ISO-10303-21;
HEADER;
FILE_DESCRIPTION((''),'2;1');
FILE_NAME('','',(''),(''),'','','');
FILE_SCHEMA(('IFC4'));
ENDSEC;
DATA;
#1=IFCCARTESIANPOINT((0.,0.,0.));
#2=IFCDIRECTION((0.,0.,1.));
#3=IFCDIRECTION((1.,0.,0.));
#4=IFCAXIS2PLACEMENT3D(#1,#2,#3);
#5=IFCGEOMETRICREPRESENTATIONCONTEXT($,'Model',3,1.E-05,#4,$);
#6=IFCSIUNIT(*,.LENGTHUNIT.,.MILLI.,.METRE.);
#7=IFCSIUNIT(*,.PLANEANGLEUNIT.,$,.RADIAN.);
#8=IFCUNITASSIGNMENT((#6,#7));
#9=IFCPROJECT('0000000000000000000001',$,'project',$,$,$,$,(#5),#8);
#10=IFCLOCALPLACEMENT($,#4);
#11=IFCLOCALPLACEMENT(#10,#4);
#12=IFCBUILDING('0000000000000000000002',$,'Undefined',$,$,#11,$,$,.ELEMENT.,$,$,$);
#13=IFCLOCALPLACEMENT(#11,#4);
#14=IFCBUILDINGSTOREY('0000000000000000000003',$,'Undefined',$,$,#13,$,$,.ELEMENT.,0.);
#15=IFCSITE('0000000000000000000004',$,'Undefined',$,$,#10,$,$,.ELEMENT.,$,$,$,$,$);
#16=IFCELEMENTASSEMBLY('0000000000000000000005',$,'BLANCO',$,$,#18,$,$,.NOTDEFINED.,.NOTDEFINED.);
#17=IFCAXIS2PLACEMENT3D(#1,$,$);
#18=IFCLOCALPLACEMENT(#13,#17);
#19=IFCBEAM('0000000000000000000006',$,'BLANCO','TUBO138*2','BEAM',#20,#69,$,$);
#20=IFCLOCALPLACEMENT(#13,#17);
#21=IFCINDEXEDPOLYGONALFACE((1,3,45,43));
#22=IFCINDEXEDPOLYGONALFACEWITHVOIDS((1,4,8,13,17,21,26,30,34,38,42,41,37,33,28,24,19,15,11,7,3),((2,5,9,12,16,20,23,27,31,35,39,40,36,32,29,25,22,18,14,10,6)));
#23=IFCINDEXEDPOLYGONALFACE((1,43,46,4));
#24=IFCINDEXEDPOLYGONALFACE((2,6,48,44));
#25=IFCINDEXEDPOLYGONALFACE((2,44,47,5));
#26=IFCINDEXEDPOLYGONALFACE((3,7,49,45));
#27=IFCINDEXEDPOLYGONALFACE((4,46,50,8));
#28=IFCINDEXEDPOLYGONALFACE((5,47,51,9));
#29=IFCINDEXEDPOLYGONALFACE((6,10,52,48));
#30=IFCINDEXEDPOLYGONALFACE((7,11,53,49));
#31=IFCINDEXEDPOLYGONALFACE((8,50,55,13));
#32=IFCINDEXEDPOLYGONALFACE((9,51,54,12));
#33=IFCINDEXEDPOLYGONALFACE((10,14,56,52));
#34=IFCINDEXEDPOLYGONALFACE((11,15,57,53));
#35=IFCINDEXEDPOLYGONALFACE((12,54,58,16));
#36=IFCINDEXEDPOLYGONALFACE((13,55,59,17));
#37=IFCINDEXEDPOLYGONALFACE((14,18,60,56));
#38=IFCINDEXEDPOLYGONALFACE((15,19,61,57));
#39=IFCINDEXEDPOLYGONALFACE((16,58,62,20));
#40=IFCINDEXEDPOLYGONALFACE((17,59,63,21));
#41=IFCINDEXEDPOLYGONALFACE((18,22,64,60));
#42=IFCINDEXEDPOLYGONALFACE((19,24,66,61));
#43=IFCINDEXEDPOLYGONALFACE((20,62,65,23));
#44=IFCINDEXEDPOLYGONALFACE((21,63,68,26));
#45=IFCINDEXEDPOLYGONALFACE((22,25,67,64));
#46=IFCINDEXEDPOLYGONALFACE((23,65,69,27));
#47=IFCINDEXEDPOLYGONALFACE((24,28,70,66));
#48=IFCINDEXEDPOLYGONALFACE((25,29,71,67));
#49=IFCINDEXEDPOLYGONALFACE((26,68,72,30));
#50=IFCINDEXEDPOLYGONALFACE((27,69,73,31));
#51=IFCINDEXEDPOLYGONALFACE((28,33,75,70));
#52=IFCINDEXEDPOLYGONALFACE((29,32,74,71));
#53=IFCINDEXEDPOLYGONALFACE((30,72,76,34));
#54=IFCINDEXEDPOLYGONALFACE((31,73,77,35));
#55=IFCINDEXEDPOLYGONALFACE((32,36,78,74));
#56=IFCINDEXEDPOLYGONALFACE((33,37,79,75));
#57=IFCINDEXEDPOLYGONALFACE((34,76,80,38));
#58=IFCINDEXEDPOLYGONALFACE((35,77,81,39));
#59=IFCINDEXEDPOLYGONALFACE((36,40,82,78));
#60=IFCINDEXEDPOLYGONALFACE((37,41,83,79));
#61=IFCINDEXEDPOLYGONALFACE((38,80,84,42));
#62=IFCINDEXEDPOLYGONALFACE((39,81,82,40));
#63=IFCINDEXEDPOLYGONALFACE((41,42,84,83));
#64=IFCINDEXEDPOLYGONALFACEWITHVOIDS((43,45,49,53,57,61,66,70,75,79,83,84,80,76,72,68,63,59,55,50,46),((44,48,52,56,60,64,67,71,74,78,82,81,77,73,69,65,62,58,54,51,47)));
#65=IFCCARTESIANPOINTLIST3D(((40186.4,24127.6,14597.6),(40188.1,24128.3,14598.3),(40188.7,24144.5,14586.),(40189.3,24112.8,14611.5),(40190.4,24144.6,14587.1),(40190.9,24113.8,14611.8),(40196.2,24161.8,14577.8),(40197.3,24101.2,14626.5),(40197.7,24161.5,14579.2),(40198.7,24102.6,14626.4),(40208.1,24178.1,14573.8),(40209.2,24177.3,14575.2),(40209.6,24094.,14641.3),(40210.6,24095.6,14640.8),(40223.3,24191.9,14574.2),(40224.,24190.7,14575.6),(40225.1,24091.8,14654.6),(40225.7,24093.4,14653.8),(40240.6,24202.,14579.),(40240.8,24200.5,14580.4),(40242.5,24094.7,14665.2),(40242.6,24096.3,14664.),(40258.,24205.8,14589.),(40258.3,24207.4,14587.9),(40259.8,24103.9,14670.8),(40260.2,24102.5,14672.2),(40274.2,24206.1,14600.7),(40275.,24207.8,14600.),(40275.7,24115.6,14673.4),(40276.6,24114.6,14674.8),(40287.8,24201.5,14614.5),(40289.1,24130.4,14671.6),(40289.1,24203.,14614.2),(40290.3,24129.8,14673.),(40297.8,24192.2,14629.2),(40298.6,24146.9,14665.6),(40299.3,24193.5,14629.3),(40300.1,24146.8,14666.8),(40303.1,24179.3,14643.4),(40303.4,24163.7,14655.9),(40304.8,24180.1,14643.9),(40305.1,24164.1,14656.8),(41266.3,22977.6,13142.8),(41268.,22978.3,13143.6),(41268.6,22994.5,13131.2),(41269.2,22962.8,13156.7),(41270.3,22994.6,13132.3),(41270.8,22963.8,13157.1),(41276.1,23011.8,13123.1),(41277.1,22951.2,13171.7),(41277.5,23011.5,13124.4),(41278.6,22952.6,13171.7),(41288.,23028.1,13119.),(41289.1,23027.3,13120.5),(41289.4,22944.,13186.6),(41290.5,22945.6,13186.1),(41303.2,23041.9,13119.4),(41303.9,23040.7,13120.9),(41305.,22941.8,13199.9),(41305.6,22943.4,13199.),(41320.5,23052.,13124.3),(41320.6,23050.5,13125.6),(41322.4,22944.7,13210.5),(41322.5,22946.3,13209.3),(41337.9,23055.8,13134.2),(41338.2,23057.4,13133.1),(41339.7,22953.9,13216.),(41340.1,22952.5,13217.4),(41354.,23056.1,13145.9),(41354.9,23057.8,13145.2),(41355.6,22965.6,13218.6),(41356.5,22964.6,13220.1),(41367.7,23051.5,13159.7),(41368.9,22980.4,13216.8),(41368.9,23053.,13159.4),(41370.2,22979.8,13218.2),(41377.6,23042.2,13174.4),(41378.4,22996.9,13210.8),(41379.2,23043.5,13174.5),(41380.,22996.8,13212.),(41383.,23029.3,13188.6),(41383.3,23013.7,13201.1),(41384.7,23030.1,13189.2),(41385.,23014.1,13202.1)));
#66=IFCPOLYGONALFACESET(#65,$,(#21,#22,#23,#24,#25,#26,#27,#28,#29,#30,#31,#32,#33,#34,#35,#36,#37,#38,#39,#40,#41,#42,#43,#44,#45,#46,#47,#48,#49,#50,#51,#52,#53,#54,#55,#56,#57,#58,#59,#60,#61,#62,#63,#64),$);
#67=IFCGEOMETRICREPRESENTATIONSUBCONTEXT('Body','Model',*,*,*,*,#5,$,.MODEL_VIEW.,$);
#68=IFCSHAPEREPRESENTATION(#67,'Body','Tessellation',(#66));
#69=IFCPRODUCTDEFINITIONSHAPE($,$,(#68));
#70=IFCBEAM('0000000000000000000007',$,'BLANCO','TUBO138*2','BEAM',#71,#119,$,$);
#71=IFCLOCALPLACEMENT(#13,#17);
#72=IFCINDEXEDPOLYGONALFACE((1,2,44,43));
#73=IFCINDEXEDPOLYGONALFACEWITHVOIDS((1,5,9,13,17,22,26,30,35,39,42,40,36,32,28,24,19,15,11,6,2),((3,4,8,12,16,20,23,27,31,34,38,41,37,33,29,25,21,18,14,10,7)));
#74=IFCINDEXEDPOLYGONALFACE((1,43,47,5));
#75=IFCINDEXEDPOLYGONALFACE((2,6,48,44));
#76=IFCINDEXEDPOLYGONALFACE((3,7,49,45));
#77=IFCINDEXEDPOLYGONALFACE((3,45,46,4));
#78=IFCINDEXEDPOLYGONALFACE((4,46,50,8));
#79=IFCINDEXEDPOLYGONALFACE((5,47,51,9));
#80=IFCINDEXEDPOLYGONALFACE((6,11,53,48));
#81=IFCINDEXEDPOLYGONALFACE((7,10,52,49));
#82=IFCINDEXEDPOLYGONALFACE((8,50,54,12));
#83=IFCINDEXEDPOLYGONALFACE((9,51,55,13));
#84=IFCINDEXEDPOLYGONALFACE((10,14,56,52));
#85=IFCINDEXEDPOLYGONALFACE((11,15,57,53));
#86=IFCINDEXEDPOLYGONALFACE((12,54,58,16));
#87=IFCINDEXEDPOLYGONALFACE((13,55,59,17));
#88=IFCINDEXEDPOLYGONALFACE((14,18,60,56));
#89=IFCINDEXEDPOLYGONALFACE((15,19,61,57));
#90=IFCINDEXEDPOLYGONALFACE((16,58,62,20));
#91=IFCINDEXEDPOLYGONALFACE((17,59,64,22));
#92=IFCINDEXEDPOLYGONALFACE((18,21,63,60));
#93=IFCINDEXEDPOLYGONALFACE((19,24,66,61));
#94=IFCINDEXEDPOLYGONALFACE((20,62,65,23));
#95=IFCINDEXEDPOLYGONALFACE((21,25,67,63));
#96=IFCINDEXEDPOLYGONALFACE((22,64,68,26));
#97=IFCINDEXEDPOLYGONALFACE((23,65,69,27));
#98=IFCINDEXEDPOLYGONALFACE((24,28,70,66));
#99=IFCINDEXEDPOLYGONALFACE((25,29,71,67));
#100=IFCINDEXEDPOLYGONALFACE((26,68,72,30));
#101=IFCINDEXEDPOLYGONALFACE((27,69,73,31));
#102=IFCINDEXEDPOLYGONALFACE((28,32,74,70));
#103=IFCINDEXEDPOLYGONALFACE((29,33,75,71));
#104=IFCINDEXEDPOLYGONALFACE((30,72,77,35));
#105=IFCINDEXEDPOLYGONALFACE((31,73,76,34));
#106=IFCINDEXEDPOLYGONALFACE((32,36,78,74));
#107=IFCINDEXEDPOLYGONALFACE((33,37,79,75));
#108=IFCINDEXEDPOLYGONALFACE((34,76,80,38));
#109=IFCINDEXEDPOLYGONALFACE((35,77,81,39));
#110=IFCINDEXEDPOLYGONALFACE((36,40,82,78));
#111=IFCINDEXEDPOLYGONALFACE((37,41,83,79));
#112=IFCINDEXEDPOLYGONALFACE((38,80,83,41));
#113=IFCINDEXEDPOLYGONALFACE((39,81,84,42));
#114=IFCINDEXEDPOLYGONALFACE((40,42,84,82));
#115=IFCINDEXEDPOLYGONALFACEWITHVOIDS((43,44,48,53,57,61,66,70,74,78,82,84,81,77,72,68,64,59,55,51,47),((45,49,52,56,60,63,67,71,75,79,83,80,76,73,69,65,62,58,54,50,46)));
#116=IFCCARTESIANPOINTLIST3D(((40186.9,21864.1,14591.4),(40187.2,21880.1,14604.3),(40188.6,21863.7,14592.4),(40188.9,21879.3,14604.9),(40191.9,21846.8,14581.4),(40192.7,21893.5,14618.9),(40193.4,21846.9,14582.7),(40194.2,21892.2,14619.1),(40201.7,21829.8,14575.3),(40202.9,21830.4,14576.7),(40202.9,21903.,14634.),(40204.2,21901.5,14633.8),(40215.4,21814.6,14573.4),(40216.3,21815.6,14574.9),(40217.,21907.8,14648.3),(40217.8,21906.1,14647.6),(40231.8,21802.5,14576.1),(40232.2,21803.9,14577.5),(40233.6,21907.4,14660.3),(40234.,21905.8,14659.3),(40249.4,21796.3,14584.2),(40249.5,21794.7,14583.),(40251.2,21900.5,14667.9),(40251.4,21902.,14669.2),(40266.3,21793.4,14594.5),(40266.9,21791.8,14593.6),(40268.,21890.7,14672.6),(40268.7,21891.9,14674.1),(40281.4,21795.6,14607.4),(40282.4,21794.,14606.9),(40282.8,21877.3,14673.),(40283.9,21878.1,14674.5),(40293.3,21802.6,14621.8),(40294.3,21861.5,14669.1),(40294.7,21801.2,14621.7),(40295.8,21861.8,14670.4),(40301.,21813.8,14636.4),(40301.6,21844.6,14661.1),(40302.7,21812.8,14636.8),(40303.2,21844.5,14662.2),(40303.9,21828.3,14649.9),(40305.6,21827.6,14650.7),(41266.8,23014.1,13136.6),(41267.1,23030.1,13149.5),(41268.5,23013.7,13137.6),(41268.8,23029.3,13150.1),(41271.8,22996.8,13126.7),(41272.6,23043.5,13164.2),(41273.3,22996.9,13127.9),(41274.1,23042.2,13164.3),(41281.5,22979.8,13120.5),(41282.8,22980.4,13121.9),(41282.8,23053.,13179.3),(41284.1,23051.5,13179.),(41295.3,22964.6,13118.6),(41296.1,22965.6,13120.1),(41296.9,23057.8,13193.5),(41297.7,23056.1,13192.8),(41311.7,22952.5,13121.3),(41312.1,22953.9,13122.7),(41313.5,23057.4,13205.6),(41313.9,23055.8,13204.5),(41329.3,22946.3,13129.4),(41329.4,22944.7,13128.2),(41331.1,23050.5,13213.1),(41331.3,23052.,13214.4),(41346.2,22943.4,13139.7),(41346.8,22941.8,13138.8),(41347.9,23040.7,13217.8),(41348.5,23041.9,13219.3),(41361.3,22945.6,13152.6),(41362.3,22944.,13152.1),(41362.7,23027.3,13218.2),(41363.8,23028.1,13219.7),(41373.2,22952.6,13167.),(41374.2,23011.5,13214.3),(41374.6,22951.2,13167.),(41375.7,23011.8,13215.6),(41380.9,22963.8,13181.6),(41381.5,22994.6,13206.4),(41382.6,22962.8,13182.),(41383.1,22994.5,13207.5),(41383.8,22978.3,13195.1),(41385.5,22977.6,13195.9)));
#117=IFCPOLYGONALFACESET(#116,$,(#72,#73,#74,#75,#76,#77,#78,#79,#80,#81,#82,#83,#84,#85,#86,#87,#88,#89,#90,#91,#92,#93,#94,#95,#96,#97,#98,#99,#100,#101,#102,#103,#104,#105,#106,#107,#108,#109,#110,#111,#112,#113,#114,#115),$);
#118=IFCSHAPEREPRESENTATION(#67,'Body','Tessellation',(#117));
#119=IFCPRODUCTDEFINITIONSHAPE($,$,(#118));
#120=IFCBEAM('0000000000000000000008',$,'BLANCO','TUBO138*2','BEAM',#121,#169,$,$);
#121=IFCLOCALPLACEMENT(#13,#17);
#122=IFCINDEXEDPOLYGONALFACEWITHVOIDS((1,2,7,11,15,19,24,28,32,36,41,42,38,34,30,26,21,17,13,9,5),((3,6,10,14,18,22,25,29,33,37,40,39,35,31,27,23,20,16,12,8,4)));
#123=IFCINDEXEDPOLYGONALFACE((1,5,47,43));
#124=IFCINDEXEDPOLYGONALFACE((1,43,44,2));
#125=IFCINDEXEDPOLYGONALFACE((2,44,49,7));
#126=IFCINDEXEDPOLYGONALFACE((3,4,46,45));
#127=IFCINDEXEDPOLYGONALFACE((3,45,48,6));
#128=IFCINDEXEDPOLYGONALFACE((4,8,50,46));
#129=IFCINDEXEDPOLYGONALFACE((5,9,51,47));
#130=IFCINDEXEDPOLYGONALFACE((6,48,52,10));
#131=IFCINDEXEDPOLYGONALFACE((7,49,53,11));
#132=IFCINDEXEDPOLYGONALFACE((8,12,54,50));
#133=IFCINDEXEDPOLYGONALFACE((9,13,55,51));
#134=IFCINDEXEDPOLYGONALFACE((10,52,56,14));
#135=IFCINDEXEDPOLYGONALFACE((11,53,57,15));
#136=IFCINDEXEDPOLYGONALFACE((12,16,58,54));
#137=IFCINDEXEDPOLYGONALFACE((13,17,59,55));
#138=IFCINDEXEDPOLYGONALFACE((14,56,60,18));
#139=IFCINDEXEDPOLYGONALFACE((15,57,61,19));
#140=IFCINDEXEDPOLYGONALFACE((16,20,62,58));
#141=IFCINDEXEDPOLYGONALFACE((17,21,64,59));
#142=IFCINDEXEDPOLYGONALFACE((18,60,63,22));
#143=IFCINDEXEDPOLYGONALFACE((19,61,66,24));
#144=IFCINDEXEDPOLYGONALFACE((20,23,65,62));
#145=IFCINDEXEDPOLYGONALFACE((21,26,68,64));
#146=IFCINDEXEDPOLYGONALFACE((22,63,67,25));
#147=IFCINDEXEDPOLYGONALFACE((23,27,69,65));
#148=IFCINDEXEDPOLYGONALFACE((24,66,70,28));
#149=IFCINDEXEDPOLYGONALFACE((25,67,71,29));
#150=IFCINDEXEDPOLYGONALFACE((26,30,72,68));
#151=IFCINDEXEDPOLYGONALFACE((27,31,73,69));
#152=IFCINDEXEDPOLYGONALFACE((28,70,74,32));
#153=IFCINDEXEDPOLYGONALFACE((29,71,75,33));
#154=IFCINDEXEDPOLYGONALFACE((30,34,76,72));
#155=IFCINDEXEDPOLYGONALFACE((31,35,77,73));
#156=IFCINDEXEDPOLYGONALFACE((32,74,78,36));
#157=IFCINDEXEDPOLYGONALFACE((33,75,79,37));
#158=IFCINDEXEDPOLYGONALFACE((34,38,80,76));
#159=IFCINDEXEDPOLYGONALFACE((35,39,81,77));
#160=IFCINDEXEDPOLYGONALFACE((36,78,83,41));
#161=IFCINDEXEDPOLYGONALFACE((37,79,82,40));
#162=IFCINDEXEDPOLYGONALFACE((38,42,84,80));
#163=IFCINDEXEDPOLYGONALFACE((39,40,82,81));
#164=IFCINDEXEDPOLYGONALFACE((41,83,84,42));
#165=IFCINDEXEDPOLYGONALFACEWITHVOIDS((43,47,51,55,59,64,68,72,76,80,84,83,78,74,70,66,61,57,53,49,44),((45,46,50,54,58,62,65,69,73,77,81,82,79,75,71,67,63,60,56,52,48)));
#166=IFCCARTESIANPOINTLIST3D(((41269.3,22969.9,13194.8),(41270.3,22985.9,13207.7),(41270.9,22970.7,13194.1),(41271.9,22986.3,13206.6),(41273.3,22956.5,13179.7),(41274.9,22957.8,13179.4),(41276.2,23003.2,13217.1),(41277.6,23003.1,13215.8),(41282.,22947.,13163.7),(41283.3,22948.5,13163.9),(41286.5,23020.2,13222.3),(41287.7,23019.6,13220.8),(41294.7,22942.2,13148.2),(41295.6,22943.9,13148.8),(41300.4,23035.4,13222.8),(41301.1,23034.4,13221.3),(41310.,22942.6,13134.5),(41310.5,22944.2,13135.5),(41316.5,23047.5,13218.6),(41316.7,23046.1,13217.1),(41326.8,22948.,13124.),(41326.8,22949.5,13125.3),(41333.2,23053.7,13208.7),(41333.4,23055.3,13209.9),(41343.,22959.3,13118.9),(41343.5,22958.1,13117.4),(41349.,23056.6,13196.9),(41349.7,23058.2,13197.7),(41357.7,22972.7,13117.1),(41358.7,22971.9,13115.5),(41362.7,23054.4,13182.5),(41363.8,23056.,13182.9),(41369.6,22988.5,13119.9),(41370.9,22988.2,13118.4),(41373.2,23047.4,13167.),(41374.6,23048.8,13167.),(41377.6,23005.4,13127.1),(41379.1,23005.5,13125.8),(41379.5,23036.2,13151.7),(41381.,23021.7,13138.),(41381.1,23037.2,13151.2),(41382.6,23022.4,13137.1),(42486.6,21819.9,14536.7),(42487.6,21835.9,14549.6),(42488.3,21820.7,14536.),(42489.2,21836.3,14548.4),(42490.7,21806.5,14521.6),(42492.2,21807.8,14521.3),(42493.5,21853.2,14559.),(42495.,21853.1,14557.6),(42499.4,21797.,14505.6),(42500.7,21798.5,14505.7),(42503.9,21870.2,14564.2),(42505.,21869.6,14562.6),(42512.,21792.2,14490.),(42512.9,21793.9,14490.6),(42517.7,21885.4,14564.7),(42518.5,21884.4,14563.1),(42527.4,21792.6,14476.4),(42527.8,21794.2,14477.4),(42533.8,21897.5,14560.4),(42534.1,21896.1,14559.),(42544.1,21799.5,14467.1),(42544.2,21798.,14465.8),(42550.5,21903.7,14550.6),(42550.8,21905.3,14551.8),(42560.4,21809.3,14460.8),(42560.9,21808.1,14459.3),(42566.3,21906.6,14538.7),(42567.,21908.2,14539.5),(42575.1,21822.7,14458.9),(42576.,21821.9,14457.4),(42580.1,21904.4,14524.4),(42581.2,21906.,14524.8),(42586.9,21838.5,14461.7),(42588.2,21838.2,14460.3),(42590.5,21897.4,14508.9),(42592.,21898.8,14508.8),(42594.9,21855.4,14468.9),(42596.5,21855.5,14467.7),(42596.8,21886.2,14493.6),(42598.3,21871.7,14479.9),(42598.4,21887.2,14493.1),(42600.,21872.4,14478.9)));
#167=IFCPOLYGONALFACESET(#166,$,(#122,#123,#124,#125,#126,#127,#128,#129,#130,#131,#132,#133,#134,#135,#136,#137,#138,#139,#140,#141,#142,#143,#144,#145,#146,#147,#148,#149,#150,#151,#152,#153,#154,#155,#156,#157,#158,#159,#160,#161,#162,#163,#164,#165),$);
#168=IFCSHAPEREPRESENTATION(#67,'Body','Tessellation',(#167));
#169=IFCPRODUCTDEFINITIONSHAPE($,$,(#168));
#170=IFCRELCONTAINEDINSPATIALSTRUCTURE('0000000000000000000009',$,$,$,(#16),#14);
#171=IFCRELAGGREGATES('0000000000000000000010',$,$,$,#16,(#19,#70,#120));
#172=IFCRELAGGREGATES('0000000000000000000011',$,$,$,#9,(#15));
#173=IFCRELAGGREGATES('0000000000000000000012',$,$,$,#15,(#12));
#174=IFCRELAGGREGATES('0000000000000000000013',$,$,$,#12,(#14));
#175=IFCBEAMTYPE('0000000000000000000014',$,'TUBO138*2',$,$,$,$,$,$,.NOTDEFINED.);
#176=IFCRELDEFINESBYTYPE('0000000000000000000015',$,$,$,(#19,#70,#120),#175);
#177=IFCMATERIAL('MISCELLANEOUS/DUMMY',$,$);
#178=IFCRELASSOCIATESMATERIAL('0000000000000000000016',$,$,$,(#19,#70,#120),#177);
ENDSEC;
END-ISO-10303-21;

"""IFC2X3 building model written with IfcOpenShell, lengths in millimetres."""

from ifc_helpers import new_model, si_unit, frame, origin_with_axes, origin_2d_with_axis, place, context, subcontext, project, spatial, hollow_circle, extrude, material, type_object, element, aggregate, save


model = new_model("IFC2X3")

# Units and contexts
model_context = context("Model", 3, precision=1e-05, world=origin_with_axes())
body_context = subcontext(model_context, "Body", "Model", "MODEL_VIEW")
ifc_project = project(units=[si_unit("LENGTHUNIT", "METRE", prefix="MILLI"), si_unit("PLANEANGLEUNIT", "RADIAN")], contexts=[model_context])

# Site, building, storey
site_placement = place(None, origin_with_axes())
site = spatial("IfcSite", under=ifc_project, at=site_placement, Name="Undefined", CompositionType="ELEMENT")
building_placement = place(site_placement, origin_with_axes())
building = spatial("IfcBuilding", under=site, at=building_placement, Name="Undefined", CompositionType="ELEMENT")
storey_placement = place(building_placement, origin_with_axes())
storey = spatial("IfcBuildingStorey", under=building, at=storey_placement, Name="Undefined", CompositionType="ELEMENT", Elevation=0.0)

# Element assembly, beams
assembly_placement = place(storey_placement, origin_with_axes())
assembly = element("IfcElementAssembly", 1, at=assembly_placement, inside=storey, Name="BLANCO", AssemblyPlace="NOTDEFINED", PredefinedType="NOTDEFINED")
ifc_material = material(Name="MISCELLANEOUS/DUMMY")
beam_type = type_object("IfcBeamType", Name="TUBO138*2", PredefinedType="NOTDEFINED")
beam_1_placement = place(assembly_placement, frame((41325.9, 23000.0, 13169.4), z_axis=(-0.497966, 0.461316, -0.734314), x_axis=(-0.503224, 0.535899, 0.677922)))
beam_1 = element("IfcBeam", 2, at=beam_1_placement, type_object=beam_type, material=ifc_material, Name="BLANCO", Description="TUBO138*2", ObjectType="BEAM", context=body_context, shape_type="SweptSolid", body=[
    extrude(hollow_circle(Radius=69.0, WallThickness=2.0, at=origin_2d_with_axis()), frame((2145.9, 0.0, 0.0), z_axis=(-1.0, 0.0, 0.0), x_axis=(0.0, -1.0, 0.0)), (0.0, 0.0, 1.0), 2145.9),
])
beam_2_placement = place(assembly_placement, frame((41325.9, 23000.0, 13169.4), z_axis=(-0.497966, -0.461316, -0.734314), x_axis=(-0.503224, -0.535899, 0.677922)))
beam_2 = element("IfcBeam", 3, at=beam_2_placement, type_object=beam_type, material=ifc_material, Name="BLANCO", Description="TUBO138*2", ObjectType="BEAM", context=body_context, shape_type="SweptSolid", body=[
    extrude(hollow_circle(Radius=69.0, WallThickness=2.0, at=origin_2d_with_axis()), frame((2145.9, 0.0, 0.0), z_axis=(-1.0, 0.0, 0.0), x_axis=(0.0, -1.0, 0.0)), (0.0, 0.0, 1.0), 2145.9),
])
beam_3_placement = place(assembly_placement, frame((41325.9, 23000.0, 13169.4), z_axis=(0.423552, -0.461316, -0.77961), x_axis=(0.567282, -0.535899, 0.625303)))
beam_3 = element("IfcBeam", 4, at=beam_3_placement, type_object=beam_type, material=ifc_material, Name="BLANCO", Description="TUBO138*2", ObjectType="BEAM", context=body_context, shape_type="SweptSolid", body=[
    extrude(hollow_circle(Radius=69.0, WallThickness=2.0, at=origin_2d_with_axis()), frame((2145.9, 0.0, 0.0), z_axis=(-1.0, 0.0, 0.0), x_axis=(0.0, -1.0, 0.0)), (0.0, 0.0, 1.0), 2145.9),
])
aggregate(assembly, [beam_1, beam_2, beam_3])

save(model, "model.ifc")
